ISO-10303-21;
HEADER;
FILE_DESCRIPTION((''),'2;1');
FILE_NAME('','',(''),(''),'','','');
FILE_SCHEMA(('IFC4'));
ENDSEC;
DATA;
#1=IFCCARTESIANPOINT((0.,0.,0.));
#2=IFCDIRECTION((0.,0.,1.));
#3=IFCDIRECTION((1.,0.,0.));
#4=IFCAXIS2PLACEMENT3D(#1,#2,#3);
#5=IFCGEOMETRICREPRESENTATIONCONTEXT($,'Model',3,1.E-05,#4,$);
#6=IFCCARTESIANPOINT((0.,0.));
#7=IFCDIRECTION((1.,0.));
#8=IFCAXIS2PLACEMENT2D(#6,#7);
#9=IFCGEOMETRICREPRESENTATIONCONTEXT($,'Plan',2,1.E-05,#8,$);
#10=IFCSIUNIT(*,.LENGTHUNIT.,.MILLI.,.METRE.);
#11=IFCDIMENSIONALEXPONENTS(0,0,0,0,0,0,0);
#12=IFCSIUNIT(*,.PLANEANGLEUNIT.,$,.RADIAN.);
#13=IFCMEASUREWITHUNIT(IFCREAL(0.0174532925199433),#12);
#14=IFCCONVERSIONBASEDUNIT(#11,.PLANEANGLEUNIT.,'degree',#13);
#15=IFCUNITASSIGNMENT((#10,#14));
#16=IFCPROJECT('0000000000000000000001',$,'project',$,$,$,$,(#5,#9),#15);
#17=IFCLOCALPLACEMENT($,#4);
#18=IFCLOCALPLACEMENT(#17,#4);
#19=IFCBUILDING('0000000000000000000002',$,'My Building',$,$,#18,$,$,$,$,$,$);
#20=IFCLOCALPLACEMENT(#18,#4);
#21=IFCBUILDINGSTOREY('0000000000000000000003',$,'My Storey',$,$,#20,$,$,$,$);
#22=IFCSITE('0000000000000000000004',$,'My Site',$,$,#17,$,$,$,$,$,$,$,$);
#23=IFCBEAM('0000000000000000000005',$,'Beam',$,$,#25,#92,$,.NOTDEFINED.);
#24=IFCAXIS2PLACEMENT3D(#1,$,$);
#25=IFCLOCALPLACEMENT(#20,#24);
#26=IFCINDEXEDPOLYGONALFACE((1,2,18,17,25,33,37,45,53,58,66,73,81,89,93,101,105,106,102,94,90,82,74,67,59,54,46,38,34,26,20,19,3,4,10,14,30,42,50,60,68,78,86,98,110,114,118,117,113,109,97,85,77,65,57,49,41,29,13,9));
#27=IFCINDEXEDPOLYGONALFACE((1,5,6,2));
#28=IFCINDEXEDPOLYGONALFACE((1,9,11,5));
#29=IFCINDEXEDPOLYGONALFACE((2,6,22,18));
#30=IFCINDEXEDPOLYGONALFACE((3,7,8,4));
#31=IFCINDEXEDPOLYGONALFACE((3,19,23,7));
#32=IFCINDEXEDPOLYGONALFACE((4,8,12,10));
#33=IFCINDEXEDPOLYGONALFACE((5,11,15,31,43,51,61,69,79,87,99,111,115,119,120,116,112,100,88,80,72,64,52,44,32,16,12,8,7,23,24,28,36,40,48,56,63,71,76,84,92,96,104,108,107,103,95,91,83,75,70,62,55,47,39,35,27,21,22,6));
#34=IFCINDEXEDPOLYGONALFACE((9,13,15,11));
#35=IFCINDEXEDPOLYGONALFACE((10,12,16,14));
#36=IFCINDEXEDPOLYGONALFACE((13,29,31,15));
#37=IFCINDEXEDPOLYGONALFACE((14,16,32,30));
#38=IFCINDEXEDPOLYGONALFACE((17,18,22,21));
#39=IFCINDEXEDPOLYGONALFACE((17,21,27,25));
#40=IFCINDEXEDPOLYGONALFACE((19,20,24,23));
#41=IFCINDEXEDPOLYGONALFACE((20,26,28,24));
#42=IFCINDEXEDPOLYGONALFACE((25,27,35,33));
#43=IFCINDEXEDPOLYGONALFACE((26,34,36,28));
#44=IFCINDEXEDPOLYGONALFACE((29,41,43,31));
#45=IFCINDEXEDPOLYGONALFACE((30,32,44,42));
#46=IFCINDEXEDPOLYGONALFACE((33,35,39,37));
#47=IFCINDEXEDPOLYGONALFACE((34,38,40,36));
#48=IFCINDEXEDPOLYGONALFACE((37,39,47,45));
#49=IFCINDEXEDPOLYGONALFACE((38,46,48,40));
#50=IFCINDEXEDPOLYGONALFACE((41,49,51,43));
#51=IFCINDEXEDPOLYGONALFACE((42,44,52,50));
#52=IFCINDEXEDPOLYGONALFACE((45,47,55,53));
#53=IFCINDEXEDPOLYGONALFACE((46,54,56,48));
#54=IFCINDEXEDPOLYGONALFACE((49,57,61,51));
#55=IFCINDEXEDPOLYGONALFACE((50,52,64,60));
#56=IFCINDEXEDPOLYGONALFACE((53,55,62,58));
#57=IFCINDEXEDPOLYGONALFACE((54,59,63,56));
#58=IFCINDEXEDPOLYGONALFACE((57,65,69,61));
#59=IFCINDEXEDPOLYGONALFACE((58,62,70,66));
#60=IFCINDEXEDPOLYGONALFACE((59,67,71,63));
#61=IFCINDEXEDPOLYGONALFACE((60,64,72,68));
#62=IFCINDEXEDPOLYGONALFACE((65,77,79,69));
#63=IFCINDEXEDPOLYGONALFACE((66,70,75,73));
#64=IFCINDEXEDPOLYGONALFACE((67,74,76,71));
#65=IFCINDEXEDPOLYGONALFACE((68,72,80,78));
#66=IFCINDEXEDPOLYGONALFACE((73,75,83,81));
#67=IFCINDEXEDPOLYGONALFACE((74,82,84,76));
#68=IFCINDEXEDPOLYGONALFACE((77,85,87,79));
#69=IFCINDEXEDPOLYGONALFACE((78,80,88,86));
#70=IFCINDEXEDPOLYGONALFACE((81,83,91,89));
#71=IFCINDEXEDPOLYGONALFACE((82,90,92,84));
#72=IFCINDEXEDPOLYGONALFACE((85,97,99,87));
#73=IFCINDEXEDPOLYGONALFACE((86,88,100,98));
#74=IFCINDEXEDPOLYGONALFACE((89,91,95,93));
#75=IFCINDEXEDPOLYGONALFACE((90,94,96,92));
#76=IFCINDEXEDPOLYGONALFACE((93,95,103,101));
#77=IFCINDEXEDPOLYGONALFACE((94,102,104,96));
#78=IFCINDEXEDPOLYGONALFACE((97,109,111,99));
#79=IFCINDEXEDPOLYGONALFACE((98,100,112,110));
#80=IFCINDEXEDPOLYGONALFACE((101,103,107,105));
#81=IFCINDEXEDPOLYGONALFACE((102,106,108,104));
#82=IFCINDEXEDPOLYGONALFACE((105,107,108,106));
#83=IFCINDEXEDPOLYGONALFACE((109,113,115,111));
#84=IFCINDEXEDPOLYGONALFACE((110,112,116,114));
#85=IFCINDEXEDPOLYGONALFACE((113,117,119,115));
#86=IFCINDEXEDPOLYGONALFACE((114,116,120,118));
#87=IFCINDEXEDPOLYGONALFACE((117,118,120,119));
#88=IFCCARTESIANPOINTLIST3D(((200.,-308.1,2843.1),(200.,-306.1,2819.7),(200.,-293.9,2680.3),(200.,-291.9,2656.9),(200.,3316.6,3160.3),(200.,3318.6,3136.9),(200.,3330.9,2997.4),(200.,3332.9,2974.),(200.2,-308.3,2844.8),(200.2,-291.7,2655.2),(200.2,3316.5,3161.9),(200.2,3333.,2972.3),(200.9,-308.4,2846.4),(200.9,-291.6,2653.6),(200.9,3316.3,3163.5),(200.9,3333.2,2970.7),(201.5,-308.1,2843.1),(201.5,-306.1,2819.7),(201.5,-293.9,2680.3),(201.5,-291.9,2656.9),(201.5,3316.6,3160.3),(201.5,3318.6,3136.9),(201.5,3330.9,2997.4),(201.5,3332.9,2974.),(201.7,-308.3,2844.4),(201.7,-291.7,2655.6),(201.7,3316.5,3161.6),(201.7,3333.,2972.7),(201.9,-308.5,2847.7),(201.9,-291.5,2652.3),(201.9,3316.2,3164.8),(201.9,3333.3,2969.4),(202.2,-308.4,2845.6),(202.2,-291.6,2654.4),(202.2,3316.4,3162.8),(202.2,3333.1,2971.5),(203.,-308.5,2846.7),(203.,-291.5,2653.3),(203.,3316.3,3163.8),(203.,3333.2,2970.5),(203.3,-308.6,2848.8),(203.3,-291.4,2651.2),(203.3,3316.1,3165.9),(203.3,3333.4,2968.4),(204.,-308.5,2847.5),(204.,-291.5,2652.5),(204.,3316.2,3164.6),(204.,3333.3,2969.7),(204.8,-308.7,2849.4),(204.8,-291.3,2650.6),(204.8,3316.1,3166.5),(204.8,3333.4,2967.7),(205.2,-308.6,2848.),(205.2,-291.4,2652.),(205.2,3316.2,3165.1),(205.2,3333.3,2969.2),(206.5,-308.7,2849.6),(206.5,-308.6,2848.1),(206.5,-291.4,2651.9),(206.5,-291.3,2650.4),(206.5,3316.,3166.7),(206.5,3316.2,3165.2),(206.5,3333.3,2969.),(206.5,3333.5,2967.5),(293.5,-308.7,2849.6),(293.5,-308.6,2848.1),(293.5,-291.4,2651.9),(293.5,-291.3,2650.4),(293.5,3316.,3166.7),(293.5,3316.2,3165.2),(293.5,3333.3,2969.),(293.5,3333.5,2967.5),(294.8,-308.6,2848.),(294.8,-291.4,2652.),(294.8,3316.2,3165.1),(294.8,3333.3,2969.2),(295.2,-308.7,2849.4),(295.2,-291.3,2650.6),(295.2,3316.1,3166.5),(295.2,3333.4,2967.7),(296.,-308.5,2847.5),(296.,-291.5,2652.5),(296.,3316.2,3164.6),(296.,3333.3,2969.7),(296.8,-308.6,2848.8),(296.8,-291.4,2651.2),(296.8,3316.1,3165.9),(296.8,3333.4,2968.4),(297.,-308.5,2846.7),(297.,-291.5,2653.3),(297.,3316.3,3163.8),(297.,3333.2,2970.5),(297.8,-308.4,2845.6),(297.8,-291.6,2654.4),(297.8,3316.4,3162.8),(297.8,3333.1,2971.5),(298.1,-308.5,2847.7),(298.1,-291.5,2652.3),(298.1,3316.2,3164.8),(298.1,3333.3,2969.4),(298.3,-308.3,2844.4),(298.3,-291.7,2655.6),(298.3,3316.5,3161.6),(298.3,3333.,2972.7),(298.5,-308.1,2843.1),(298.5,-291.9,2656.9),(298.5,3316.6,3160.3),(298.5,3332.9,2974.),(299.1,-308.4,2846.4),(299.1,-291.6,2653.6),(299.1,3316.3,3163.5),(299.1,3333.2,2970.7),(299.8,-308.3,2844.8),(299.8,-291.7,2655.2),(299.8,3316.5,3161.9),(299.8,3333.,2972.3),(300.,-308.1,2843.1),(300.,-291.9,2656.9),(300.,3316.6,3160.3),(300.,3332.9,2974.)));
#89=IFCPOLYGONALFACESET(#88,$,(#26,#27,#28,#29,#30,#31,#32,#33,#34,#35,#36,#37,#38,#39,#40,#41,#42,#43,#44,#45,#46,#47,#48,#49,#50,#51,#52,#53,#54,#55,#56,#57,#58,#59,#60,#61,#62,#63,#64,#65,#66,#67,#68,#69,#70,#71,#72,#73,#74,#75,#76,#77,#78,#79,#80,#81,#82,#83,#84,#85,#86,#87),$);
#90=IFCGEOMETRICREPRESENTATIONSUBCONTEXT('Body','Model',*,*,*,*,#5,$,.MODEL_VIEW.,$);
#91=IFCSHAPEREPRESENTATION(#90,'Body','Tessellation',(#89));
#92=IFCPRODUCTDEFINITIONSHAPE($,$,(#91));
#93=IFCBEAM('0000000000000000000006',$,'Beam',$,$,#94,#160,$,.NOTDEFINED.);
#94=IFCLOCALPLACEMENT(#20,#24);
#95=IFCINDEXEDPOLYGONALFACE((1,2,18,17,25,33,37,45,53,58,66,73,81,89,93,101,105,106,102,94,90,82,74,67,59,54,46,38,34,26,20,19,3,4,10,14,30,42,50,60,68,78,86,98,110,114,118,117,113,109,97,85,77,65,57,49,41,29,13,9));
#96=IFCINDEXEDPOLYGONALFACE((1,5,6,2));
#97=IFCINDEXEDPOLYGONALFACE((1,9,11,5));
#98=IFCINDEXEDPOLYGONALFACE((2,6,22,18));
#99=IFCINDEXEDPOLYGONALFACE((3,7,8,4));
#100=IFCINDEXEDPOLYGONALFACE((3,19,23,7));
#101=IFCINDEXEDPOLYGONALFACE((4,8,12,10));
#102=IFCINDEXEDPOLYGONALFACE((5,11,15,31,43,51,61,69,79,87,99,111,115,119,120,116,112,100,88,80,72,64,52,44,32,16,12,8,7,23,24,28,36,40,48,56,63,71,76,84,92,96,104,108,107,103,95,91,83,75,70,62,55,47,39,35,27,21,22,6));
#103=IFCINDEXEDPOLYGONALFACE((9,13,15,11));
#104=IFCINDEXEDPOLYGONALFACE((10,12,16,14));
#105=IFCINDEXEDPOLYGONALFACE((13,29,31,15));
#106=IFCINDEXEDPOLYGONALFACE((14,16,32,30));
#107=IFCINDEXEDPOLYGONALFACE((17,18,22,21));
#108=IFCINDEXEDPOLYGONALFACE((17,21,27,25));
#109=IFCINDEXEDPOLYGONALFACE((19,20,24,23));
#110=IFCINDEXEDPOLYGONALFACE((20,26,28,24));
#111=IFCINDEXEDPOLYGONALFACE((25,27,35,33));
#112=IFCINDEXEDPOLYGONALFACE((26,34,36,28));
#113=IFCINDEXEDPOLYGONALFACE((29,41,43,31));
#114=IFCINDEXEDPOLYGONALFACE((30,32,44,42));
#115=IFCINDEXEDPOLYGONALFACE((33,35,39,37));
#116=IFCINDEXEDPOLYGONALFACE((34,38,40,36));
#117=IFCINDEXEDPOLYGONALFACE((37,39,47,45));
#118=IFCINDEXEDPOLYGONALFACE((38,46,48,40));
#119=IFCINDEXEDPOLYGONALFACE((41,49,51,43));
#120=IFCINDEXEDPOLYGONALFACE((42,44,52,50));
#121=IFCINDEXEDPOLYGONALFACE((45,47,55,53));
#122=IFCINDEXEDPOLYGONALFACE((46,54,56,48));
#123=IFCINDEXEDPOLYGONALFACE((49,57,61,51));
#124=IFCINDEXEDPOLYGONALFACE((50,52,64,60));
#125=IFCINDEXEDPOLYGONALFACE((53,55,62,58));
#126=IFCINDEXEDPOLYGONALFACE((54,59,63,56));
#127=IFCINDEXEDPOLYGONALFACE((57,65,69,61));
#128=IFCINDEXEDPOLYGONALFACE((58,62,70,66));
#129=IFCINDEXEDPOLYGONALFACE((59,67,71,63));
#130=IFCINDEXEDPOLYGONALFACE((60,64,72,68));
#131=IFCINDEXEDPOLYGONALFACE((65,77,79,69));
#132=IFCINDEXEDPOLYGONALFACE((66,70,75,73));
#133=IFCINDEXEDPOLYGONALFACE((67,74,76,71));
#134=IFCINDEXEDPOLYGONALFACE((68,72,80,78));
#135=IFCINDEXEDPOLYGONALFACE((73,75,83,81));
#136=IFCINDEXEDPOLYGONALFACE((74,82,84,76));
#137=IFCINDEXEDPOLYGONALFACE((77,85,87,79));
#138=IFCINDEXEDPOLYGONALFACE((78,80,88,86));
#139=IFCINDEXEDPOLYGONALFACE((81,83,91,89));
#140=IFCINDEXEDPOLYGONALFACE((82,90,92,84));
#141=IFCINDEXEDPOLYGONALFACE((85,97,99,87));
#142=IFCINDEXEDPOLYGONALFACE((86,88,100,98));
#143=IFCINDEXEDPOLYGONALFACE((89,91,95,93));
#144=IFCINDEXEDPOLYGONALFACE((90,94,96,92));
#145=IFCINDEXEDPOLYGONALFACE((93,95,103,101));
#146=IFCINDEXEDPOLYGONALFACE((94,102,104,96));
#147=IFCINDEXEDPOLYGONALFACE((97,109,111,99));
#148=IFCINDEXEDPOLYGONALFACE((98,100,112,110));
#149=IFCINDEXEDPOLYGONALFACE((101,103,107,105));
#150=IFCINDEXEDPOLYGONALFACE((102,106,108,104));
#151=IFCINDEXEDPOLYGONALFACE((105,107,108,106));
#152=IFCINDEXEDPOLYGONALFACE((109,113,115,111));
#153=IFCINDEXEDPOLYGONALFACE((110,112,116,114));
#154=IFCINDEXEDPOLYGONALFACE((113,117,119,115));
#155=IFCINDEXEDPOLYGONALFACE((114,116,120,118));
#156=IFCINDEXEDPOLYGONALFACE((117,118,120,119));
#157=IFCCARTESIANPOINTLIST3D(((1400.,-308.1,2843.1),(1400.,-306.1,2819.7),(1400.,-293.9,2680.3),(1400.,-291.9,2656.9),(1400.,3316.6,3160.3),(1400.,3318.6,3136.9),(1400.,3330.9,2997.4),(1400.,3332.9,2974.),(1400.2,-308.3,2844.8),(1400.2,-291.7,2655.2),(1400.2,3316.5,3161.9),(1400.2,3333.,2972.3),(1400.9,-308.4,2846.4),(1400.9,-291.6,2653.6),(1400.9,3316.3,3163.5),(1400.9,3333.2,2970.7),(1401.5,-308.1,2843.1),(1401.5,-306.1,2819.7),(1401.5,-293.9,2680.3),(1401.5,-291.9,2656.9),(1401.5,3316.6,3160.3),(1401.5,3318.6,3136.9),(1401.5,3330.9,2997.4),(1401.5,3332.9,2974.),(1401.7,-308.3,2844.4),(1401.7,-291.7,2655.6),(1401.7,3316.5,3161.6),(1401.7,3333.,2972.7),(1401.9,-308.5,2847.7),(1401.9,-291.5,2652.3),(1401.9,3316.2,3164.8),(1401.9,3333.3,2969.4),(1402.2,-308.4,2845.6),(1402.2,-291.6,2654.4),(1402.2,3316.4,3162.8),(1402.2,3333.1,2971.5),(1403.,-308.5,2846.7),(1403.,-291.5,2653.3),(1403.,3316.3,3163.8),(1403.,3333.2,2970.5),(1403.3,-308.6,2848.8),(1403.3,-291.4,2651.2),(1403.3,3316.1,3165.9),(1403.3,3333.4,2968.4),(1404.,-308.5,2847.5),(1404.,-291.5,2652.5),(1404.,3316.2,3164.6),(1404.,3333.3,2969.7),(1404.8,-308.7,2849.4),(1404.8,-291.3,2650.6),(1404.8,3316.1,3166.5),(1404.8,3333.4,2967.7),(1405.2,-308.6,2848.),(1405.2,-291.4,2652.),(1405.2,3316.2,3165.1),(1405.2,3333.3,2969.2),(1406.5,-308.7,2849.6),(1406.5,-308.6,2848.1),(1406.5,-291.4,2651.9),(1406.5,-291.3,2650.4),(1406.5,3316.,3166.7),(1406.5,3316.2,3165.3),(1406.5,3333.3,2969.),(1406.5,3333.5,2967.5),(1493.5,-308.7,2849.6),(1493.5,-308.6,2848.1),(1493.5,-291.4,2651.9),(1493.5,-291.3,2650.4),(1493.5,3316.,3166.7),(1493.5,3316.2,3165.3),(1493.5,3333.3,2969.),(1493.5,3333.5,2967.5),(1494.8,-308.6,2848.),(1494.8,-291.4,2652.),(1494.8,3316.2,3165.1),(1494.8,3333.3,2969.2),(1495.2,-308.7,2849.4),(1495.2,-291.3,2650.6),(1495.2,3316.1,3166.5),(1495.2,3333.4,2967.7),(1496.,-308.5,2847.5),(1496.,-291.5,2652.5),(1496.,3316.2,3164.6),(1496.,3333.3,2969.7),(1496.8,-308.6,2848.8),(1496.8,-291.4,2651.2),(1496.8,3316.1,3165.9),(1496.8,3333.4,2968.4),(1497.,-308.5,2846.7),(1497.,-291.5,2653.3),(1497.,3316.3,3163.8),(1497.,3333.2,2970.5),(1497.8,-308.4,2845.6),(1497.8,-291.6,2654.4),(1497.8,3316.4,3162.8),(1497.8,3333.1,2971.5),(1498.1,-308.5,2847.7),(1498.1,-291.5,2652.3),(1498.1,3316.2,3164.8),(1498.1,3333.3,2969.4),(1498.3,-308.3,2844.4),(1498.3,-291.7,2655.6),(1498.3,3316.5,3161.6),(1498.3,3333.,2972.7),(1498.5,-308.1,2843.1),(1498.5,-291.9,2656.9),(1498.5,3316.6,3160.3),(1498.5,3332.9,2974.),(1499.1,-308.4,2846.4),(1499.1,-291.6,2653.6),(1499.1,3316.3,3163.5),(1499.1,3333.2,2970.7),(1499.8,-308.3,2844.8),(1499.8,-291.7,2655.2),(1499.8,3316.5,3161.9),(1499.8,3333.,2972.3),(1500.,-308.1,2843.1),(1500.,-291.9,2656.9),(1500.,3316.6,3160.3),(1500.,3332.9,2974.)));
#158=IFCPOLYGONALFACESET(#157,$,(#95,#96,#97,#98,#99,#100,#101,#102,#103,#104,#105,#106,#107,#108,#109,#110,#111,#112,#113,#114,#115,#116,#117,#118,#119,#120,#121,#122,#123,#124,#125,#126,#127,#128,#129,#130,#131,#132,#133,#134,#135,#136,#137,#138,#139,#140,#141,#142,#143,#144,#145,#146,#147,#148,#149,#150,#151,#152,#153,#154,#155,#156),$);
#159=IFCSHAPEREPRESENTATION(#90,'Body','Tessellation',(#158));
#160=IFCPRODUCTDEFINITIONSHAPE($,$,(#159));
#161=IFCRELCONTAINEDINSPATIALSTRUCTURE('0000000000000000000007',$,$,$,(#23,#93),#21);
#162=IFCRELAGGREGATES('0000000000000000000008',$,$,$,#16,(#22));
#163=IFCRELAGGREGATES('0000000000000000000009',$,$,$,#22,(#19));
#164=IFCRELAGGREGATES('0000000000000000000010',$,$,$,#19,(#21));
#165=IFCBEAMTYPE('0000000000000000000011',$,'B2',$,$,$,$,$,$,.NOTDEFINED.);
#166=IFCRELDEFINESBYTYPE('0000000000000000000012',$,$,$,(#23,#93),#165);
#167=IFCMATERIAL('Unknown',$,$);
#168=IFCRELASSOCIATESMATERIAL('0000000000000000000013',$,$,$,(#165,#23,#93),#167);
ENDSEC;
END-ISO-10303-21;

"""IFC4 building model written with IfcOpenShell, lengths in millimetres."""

from ifc_helpers import new_model, entity, si_unit, converted_unit, frame, origin_with_axes, origin_2d_with_axis, place, context, subcontext, project, spatial, c_section, extrude, material, material_profile, profile_set, profile_usage, type_object, element, save


model = new_model("IFC4")

# Units and contexts
model_context = context("Model", 3, precision=1e-05, world=origin_with_axes())
plan_context = context("Plan", 2, precision=1e-05, world=origin_2d_with_axis())
body_context = subcontext(model_context, "Body", "Model", "MODEL_VIEW")
ifc_project = project(units=[si_unit("LENGTHUNIT", "METRE", prefix="MILLI"), converted_unit("PLANEANGLEUNIT", "degree", entity("IfcReal", 0.0174532925199433), si_unit("PLANEANGLEUNIT", "RADIAN"), dimensions=[0, 0, 0, 0, 0, 0, 0])], contexts=[model_context, plan_context])

# Site, building, storey
site_placement = place(None, origin_with_axes())
site = spatial("IfcSite", under=ifc_project, at=site_placement, Name="My Site")
building_placement = place(site_placement, origin_with_axes())
building = spatial("IfcBuilding", under=site, at=building_placement, Name="My Building")
storey_placement = place(building_placement, origin_with_axes())
storey = spatial("IfcBuildingStorey", under=building, at=storey_placement, Name="My Storey")

# Shared definitions
ifc_material = material(Name="Unknown")

# Beams
ifc_material_profile_1 = material_profile(ifc_material, c_section(Depth=200.0, Width=100.0, WallThickness=1.5, Girth=30.0, InternalFilletRadius=5.0))
ifc_profile_set_1 = profile_set([ifc_material_profile_1])
ifc_profile_usage_1 = profile_usage(ifc_profile_set_1, cardinal=5)
beam_type_1 = type_object("IfcBeamType", Name="B2", PredefinedType="NOTDEFINED", material=ifc_profile_set_1)
beam_1_placement = place(storey_placement, frame((250.0, -300.0, 2750.0), z_axis=(0.0, 0.996195, 0.087156), x_axis=(-1.0, 0.0, 0.0)))
element("IfcBeam", 1, at=beam_1_placement, inside=storey, type_object=beam_type_1, material=ifc_profile_usage_1, Name="Beam", PredefinedType="NOTDEFINED", context=body_context, shape_type="SweptSolid", body=[
    extrude(c_section(Depth=200.0, Width=100.0, WallThickness=1.5, Girth=30.0, InternalFilletRadius=5.0), origin_with_axes(), (0.0, 0.0, 1.0), 3638.6),
])
ifc_profile_usage_2 = profile_usage(ifc_profile_set_1, cardinal=5)
beam_2_placement = place(storey_placement, frame((1450.0, -300.0, 2750.0), z_axis=(0.0, 0.996195, 0.087156), x_axis=(-1.0, 0.0, 0.0)))
element("IfcBeam", 2, at=beam_2_placement, inside=storey, type_object=beam_type_1, material=ifc_profile_usage_2, Name="Beam", PredefinedType="NOTDEFINED", context=body_context, shape_type="SweptSolid", body=[
    extrude(c_section(Depth=200.0, Width=100.0, WallThickness=1.5, Girth=30.0, InternalFilletRadius=5.0), origin_with_axes(), (0.0, 0.0, 1.0), 3638.6),
])

save(model, "model.ifc")
